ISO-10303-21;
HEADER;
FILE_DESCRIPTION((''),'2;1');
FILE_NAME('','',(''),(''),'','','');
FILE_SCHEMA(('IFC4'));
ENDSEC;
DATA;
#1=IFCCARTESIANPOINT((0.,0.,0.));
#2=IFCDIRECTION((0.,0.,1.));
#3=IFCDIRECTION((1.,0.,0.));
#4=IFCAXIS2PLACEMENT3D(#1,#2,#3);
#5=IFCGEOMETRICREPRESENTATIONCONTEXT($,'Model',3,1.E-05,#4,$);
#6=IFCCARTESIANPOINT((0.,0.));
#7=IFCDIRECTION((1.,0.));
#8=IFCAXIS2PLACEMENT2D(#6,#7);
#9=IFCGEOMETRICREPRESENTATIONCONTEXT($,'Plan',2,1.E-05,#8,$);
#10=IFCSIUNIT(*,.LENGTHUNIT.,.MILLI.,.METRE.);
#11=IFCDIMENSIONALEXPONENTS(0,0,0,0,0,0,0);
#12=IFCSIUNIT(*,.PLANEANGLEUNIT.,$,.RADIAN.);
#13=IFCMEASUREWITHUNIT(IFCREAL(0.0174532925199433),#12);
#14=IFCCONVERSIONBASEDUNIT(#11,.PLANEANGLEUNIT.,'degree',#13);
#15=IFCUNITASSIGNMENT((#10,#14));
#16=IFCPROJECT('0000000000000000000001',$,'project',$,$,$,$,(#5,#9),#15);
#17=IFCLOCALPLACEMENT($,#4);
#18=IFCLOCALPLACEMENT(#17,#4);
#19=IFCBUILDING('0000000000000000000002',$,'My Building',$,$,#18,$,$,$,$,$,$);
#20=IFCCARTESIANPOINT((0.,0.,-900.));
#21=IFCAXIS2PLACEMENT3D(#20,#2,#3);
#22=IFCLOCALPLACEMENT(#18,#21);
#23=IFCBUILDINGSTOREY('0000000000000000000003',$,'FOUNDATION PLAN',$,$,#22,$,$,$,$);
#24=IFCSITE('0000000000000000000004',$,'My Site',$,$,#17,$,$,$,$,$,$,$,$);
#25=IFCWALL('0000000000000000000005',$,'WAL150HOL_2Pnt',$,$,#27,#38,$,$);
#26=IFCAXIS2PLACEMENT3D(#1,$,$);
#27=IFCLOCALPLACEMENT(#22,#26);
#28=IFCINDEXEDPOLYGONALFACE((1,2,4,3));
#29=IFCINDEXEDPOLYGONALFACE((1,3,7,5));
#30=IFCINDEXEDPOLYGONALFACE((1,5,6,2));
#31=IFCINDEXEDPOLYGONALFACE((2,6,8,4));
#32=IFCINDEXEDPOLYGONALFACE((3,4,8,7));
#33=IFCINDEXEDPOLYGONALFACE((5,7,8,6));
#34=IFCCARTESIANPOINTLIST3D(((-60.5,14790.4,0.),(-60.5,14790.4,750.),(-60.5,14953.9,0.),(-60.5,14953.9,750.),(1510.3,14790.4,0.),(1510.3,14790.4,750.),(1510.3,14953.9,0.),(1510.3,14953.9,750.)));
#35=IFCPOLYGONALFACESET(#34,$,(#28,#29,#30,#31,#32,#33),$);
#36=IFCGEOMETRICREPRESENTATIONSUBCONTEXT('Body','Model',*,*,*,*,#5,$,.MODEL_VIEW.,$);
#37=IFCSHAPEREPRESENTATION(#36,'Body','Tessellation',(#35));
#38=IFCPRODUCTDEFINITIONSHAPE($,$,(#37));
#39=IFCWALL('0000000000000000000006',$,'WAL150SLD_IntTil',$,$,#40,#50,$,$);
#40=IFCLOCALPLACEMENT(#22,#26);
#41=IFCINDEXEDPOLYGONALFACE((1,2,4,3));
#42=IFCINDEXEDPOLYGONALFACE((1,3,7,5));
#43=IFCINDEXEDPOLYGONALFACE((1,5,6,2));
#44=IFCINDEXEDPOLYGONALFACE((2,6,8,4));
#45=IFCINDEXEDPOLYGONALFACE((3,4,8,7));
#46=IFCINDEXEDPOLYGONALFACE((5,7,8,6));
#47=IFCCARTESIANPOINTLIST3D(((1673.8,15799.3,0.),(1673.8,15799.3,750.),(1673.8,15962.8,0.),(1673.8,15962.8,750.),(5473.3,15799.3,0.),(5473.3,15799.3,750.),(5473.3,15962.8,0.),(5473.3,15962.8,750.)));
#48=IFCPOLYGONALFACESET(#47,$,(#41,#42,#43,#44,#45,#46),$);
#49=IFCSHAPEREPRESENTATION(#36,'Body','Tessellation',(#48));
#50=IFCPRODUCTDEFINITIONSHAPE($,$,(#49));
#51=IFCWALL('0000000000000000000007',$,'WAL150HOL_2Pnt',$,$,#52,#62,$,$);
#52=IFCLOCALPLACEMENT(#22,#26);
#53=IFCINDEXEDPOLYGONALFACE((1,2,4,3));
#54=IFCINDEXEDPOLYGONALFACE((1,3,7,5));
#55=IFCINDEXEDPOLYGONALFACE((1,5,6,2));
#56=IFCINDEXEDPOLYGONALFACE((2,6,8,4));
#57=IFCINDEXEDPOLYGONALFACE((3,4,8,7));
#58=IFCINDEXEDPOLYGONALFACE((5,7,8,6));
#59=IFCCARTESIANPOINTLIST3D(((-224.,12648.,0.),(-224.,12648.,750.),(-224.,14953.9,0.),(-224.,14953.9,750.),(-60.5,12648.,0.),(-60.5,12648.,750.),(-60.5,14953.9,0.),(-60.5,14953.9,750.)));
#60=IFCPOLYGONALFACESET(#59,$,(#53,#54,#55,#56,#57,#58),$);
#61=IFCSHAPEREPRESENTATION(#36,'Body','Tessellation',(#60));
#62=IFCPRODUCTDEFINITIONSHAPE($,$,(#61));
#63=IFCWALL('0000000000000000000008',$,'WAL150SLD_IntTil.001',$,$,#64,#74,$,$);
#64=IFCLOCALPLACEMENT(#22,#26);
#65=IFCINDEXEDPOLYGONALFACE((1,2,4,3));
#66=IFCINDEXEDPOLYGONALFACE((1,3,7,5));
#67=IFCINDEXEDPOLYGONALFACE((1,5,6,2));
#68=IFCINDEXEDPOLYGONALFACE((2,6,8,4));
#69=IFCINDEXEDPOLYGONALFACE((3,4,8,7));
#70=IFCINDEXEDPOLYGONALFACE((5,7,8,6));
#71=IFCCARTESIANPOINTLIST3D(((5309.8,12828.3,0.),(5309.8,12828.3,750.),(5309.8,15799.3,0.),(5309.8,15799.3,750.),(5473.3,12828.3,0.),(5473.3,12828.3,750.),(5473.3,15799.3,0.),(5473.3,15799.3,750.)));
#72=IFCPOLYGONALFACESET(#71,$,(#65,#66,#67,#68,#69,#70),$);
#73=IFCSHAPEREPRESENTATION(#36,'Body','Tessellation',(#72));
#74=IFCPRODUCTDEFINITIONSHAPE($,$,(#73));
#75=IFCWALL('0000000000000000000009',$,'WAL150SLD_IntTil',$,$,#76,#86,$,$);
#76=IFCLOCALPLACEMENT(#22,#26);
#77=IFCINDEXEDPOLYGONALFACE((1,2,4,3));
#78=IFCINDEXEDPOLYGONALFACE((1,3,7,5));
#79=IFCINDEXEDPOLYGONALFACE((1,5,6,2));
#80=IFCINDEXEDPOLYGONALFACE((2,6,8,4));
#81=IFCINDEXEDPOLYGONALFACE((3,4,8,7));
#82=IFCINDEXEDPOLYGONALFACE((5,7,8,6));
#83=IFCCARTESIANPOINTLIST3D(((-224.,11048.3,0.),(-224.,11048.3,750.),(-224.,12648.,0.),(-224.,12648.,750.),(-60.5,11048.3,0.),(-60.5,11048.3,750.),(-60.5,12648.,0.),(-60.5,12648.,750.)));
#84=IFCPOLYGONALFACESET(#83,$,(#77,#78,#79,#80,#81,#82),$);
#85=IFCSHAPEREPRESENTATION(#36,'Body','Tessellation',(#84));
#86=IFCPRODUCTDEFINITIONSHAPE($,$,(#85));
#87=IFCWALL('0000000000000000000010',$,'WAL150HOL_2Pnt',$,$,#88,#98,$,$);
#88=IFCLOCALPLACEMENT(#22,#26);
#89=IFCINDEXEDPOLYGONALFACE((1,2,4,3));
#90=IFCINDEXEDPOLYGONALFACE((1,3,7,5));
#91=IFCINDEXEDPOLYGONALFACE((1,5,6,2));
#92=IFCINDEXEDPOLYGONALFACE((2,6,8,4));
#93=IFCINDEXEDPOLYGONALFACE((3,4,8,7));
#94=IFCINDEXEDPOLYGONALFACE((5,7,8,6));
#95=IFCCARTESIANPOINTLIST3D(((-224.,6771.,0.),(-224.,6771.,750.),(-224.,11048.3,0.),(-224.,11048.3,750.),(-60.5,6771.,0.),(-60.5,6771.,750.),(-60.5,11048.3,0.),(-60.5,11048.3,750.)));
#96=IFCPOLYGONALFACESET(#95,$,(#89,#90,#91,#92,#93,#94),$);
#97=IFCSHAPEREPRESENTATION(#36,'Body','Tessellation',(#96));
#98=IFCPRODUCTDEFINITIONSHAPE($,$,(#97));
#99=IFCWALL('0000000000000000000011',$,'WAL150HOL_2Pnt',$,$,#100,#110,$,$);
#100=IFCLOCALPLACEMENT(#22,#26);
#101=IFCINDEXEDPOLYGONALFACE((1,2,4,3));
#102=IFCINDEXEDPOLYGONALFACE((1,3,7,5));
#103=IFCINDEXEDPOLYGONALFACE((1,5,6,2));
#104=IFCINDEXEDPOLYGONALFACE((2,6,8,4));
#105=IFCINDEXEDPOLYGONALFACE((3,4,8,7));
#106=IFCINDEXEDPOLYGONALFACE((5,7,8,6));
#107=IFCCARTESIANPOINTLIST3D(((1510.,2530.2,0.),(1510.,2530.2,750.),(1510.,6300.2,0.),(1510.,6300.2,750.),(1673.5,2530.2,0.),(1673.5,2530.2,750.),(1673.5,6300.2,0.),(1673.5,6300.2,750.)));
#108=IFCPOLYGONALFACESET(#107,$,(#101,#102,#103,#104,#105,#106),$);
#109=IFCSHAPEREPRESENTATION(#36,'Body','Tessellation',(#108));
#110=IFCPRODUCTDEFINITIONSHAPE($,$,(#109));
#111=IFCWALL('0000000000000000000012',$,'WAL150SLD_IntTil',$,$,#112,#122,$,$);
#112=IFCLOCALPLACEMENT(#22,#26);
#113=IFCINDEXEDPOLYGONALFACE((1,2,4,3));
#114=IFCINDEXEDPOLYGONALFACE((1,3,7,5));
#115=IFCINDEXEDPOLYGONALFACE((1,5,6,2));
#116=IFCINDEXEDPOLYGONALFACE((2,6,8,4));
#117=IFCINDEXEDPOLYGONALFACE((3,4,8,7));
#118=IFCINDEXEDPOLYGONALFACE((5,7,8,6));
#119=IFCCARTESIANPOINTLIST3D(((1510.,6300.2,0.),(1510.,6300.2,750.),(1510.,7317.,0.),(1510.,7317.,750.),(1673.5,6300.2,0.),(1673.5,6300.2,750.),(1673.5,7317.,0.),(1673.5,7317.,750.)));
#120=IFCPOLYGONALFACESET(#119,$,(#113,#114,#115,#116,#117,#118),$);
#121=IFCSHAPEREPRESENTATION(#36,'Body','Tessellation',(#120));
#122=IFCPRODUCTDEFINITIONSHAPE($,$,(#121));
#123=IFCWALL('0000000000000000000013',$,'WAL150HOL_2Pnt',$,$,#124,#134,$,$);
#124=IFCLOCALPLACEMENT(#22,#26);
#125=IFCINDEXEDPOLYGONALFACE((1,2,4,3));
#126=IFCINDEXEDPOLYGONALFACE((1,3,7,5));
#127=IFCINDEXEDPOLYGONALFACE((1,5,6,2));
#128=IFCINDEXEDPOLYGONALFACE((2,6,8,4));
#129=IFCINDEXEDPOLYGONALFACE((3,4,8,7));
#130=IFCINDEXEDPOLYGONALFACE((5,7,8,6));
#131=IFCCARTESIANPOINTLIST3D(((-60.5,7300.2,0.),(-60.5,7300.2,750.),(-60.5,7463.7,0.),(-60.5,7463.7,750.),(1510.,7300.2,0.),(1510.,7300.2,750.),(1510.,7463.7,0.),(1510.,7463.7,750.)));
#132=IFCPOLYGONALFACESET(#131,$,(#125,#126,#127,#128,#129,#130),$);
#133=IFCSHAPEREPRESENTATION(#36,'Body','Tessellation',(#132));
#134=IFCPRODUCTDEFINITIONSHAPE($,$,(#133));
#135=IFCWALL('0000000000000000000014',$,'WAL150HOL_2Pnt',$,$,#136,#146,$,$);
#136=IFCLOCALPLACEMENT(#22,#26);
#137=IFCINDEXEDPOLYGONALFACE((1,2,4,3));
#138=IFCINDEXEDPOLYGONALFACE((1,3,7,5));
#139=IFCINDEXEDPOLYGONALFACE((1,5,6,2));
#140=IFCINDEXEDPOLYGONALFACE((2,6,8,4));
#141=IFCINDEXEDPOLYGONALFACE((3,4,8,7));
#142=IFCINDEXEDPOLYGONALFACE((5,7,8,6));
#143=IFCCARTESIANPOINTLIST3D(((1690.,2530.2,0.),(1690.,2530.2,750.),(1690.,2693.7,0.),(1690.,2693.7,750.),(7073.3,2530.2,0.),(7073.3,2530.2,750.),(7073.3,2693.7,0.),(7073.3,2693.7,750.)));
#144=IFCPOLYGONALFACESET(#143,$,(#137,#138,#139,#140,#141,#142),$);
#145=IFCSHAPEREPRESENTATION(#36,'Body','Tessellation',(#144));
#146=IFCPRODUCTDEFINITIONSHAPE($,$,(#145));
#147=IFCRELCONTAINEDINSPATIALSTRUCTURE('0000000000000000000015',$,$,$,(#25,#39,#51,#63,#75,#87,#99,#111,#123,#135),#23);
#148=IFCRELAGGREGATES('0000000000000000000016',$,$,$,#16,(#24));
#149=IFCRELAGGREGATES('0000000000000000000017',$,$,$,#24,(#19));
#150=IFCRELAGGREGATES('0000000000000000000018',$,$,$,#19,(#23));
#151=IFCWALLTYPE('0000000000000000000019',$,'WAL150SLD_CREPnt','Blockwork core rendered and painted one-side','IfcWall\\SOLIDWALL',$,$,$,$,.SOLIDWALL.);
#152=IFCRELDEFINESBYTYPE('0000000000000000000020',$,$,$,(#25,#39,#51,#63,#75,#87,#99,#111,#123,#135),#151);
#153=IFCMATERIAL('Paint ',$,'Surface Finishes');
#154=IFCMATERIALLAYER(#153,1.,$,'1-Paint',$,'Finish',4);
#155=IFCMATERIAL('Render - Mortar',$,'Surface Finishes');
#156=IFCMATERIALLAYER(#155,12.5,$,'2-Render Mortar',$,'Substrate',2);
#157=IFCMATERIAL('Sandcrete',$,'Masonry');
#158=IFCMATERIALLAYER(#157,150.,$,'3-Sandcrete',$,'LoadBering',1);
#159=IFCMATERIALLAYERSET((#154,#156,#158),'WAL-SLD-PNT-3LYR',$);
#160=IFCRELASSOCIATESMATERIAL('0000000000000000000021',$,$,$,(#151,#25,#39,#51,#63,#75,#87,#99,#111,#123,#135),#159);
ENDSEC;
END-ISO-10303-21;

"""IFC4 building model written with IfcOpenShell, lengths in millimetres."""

from ifc_helpers import new_model, entity, si_unit, converted_unit, frame, origin_with_axes, origin_2d_with_axis, place, context, subcontext, project, spatial, indexed_curve, outline, extrude, material, layer, layer_set, layer_usage, type_object, element, save


model = new_model("IFC4")

# Units and contexts
model_context = context("Model", 3, precision=1e-05, world=origin_with_axes())
plan_context = context("Plan", 2, precision=1e-05, world=origin_2d_with_axis())
body_context = subcontext(model_context, "Body", "Model", "MODEL_VIEW")
ifc_project = project(units=[si_unit("LENGTHUNIT", "METRE", prefix="MILLI"), converted_unit("PLANEANGLEUNIT", "degree", entity("IfcReal", 0.0174532925199433), si_unit("PLANEANGLEUNIT", "RADIAN"), dimensions=[0, 0, 0, 0, 0, 0, 0])], contexts=[model_context, plan_context])

# Site, building, storey
site_placement = place(None, origin_with_axes())
site = spatial("IfcSite", under=ifc_project, at=site_placement, Name="My Site")
building_placement = place(site_placement, origin_with_axes())
building = spatial("IfcBuilding", under=site, at=building_placement, Name="My Building")
storey_placement = place(building_placement, frame((0.0, 0.0, -900.0), z_axis=(0.0, 0.0, 1.0), x_axis=(1.0, 0.0, 0.0)))
storey = spatial("IfcBuildingStorey", under=building, at=storey_placement, Name="FOUNDATION PLAN")

# Walls
ifc_material_1 = material(Name="Sandcrete", Category="Masonry")
ifc_material_2 = material(Name="Paint ", Category="Surface Finishes")
ifc_layer_1 = layer(ifc_material_2, 1.0, Name="1-Paint", Category="Finish", Priority=4)
ifc_material_3 = material(Name="Render - Mortar", Category="Surface Finishes")
ifc_layer_2 = layer(ifc_material_3, 12.5, Name="2-Render Mortar", Category="Substrate", Priority=2)
ifc_layer_3 = layer(ifc_material_1, 150.0, Name="3-Sandcrete", Category="LoadBering", Priority=1)
ifc_layer_set_1 = layer_set([ifc_layer_1, ifc_layer_2, ifc_layer_3], Name="WAL-SLD-PNT-3LYR")
wall_type_1 = type_object("IfcWallType", Name="WAL150SLD_CREPnt", Description="Blockwork core rendered and painted one-side", ApplicableOccurrence="IfcWall\\SOLIDWALL", PredefinedType="SOLIDWALL", material=ifc_layer_set_1)
ifc_layer_usage_1 = layer_usage(ifc_layer_set_1, "AXIS2", "POSITIVE", 0.0)
wall_1_placement = place(storey_placement, frame((1510.3, 14953.9, 0.0), z_axis=(0.0, 0.0, 1.0), x_axis=(-1.0, 0.0, 0.0)))
element("IfcWall", 1, at=wall_1_placement, inside=storey, type_object=wall_type_1, material=ifc_layer_usage_1, Name="WAL150HOL_2Pnt", context=body_context, shape_type="SweptSolid", body=[
    extrude(outline(indexed_curve([(0.0, 0.0), (0.0, 163.5), (1570.8, 163.5), (1570.8, 0.0), (0.0, 0.0)], self_intersect=False)), origin_with_axes(), (0.0, 0.0, 1.0), 750.0),
])
ifc_layer_usage_2 = layer_usage(ifc_layer_set_1, "AXIS2", "POSITIVE", 0.0)
wall_2_placement = place(storey_placement, frame((5473.3, 15962.8, 0.0), z_axis=(0.0, 0.0, 1.0), x_axis=(-1.0, 0.000001, 0.0)))
element("IfcWall", 2, at=wall_2_placement, inside=storey, type_object=wall_type_1, material=ifc_layer_usage_2, Name="WAL150SLD_IntTil", context=body_context, shape_type="SweptSolid", body=[
    extrude(outline(indexed_curve([(0.0, 0.0), (0.0, 163.5), (3799.5, 163.5), (3799.5, 0.0), (0.0, 0.0)], self_intersect=False)), origin_with_axes(), (0.0, 0.0, 1.0), 750.0),
])
ifc_layer_usage_3 = layer_usage(ifc_layer_set_1, "AXIS2", "POSITIVE", 0.0)
wall_3_placement = place(storey_placement, frame((-224.0, 14953.9, 0.0), z_axis=(0.0, 0.0, 1.0), x_axis=(0.0, -1.0, 0.0)))
element("IfcWall", 3, at=wall_3_placement, inside=storey, type_object=wall_type_1, material=ifc_layer_usage_3, Name="WAL150HOL_2Pnt", context=body_context, shape_type="SweptSolid", body=[
    extrude(outline(indexed_curve([(0.0, 0.0), (0.0, 163.5), (2305.9, 163.5), (2305.9, 0.0), (0.0, 0.0)], self_intersect=False)), origin_with_axes(), (0.0, 0.0, 1.0), 750.0),
])
ifc_layer_usage_4 = layer_usage(ifc_layer_set_1, "AXIS2", "POSITIVE", 0.0)
wall_4_placement = place(storey_placement, frame((5473.3, 12828.3, 0.0), z_axis=(0.0, 0.0, 1.0), x_axis=(0.000001, 1.0, 0.0)))
element("IfcWall", 4, at=wall_4_placement, inside=storey, type_object=wall_type_1, material=ifc_layer_usage_4, Name="WAL150SLD_IntTil.001", context=body_context, shape_type="SweptSolid", body=[
    extrude(outline(indexed_curve([(0.0, 0.0), (0.0, 163.5), (2971.0, 163.5), (2971.0, 0.0), (0.0, 0.0)], self_intersect=False)), origin_with_axes(), (0.0, 0.0, 1.0), 750.0),
])
ifc_layer_usage_5 = layer_usage(ifc_layer_set_1, "AXIS2", "POSITIVE", 0.0)
wall_5_placement = place(storey_placement, frame((-224.0, 12648.0, 0.0), z_axis=(0.0, 0.0, 1.0), x_axis=(0.0, -1.0, 0.0)))
element("IfcWall", 5, at=wall_5_placement, inside=storey, type_object=wall_type_1, material=ifc_layer_usage_5, Name="WAL150SLD_IntTil", context=body_context, shape_type="SweptSolid", body=[
    extrude(outline(indexed_curve([(0.0, 0.0), (0.0, 163.5), (1599.7, 163.5), (1599.7, 0.0), (0.0, 0.0)], self_intersect=False)), origin_with_axes(), (0.0, 0.0, 1.0), 750.0),
])
ifc_layer_usage_6 = layer_usage(ifc_layer_set_1, "AXIS2", "POSITIVE", 0.0)
wall_6_placement = place(storey_placement, frame((-224.0, 11048.3, 0.0), z_axis=(0.0, 0.0, 1.0), x_axis=(0.0, -1.0, 0.0)))
element("IfcWall", 6, at=wall_6_placement, inside=storey, type_object=wall_type_1, material=ifc_layer_usage_6, Name="WAL150HOL_2Pnt", context=body_context, shape_type="SweptSolid", body=[
    extrude(outline(indexed_curve([(0.0, 0.0), (0.0, 163.5), (4277.3, 163.5), (4277.3, 0.0), (0.0, 0.0)], self_intersect=False)), origin_with_axes(), (0.0, 0.0, 1.0), 750.0),
])
ifc_layer_usage_7 = layer_usage(ifc_layer_set_1, "AXIS2", "POSITIVE", 0.0)
wall_7_placement = place(storey_placement, frame((1510.0, 6300.2, 0.0), z_axis=(0.0, 0.0, 1.0), x_axis=(-0.000001, -1.0, 0.0)))
element("IfcWall", 7, at=wall_7_placement, inside=storey, type_object=wall_type_1, material=ifc_layer_usage_7, Name="WAL150HOL_2Pnt", context=body_context, shape_type="SweptSolid", body=[
    extrude(outline(indexed_curve([(0.0, 0.0), (0.0, 163.5), (3770.0, 163.5), (3770.0, 0.0), (0.0, 0.0)], self_intersect=False)), origin_with_axes(), (0.0, 0.0, 1.0), 750.0),
])
ifc_layer_usage_8 = layer_usage(ifc_layer_set_1, "AXIS2", "POSITIVE", 0.0)
wall_8_placement = place(storey_placement, frame((1510.0, 7317.0, 0.0), z_axis=(0.0, 0.0, 1.0), x_axis=(-0.000001, -1.0, 0.0)))
element("IfcWall", 8, at=wall_8_placement, inside=storey, type_object=wall_type_1, material=ifc_layer_usage_8, Name="WAL150SLD_IntTil", context=body_context, shape_type="SweptSolid", body=[
    extrude(outline(indexed_curve([(0.0, 0.0), (0.0, 163.5), (1016.8, 163.5), (1016.8, 0.0), (0.0, 0.0)], self_intersect=False)), origin_with_axes(), (0.0, 0.0, 1.0), 750.0),
])
ifc_layer_usage_9 = layer_usage(ifc_layer_set_1, "AXIS2", "POSITIVE", 0.0)
wall_9_placement = place(storey_placement, frame((-60.5, 7300.2, 0.0), z_axis=(0.0, 0.0, 1.0), x_axis=(1.0, 0.0, 0.0)))
element("IfcWall", 9, at=wall_9_placement, inside=storey, type_object=wall_type_1, material=ifc_layer_usage_9, Name="WAL150HOL_2Pnt", context=body_context, shape_type="SweptSolid", body=[
    extrude(outline(indexed_curve([(0.0, 0.0), (0.0, 163.5), (1570.5, 163.5), (1570.5, 0.0), (0.0, 0.0)], self_intersect=False)), origin_with_axes(), (0.0, 0.0, 1.0), 750.0),
])
ifc_layer_usage_10 = layer_usage(ifc_layer_set_1, "AXIS2", "POSITIVE", 0.0)
wall_10_placement = place(storey_placement, frame((1690.0, 2530.2, 0.0), z_axis=(0.0, 0.0, 1.0), x_axis=(1.0, 0.0, 0.0)))
element("IfcWall", 10, at=wall_10_placement, inside=storey, type_object=wall_type_1, material=ifc_layer_usage_10, Name="WAL150HOL_2Pnt", context=body_context, shape_type="SweptSolid", body=[
    extrude(outline(indexed_curve([(0.0, 0.0), (0.0, 163.5), (5383.3, 163.5), (5383.3, 0.0), (0.0, 0.0)], self_intersect=False)), origin_with_axes(), (0.0, 0.0, 1.0), 750.0),
])

save(model, "model.ifc")
